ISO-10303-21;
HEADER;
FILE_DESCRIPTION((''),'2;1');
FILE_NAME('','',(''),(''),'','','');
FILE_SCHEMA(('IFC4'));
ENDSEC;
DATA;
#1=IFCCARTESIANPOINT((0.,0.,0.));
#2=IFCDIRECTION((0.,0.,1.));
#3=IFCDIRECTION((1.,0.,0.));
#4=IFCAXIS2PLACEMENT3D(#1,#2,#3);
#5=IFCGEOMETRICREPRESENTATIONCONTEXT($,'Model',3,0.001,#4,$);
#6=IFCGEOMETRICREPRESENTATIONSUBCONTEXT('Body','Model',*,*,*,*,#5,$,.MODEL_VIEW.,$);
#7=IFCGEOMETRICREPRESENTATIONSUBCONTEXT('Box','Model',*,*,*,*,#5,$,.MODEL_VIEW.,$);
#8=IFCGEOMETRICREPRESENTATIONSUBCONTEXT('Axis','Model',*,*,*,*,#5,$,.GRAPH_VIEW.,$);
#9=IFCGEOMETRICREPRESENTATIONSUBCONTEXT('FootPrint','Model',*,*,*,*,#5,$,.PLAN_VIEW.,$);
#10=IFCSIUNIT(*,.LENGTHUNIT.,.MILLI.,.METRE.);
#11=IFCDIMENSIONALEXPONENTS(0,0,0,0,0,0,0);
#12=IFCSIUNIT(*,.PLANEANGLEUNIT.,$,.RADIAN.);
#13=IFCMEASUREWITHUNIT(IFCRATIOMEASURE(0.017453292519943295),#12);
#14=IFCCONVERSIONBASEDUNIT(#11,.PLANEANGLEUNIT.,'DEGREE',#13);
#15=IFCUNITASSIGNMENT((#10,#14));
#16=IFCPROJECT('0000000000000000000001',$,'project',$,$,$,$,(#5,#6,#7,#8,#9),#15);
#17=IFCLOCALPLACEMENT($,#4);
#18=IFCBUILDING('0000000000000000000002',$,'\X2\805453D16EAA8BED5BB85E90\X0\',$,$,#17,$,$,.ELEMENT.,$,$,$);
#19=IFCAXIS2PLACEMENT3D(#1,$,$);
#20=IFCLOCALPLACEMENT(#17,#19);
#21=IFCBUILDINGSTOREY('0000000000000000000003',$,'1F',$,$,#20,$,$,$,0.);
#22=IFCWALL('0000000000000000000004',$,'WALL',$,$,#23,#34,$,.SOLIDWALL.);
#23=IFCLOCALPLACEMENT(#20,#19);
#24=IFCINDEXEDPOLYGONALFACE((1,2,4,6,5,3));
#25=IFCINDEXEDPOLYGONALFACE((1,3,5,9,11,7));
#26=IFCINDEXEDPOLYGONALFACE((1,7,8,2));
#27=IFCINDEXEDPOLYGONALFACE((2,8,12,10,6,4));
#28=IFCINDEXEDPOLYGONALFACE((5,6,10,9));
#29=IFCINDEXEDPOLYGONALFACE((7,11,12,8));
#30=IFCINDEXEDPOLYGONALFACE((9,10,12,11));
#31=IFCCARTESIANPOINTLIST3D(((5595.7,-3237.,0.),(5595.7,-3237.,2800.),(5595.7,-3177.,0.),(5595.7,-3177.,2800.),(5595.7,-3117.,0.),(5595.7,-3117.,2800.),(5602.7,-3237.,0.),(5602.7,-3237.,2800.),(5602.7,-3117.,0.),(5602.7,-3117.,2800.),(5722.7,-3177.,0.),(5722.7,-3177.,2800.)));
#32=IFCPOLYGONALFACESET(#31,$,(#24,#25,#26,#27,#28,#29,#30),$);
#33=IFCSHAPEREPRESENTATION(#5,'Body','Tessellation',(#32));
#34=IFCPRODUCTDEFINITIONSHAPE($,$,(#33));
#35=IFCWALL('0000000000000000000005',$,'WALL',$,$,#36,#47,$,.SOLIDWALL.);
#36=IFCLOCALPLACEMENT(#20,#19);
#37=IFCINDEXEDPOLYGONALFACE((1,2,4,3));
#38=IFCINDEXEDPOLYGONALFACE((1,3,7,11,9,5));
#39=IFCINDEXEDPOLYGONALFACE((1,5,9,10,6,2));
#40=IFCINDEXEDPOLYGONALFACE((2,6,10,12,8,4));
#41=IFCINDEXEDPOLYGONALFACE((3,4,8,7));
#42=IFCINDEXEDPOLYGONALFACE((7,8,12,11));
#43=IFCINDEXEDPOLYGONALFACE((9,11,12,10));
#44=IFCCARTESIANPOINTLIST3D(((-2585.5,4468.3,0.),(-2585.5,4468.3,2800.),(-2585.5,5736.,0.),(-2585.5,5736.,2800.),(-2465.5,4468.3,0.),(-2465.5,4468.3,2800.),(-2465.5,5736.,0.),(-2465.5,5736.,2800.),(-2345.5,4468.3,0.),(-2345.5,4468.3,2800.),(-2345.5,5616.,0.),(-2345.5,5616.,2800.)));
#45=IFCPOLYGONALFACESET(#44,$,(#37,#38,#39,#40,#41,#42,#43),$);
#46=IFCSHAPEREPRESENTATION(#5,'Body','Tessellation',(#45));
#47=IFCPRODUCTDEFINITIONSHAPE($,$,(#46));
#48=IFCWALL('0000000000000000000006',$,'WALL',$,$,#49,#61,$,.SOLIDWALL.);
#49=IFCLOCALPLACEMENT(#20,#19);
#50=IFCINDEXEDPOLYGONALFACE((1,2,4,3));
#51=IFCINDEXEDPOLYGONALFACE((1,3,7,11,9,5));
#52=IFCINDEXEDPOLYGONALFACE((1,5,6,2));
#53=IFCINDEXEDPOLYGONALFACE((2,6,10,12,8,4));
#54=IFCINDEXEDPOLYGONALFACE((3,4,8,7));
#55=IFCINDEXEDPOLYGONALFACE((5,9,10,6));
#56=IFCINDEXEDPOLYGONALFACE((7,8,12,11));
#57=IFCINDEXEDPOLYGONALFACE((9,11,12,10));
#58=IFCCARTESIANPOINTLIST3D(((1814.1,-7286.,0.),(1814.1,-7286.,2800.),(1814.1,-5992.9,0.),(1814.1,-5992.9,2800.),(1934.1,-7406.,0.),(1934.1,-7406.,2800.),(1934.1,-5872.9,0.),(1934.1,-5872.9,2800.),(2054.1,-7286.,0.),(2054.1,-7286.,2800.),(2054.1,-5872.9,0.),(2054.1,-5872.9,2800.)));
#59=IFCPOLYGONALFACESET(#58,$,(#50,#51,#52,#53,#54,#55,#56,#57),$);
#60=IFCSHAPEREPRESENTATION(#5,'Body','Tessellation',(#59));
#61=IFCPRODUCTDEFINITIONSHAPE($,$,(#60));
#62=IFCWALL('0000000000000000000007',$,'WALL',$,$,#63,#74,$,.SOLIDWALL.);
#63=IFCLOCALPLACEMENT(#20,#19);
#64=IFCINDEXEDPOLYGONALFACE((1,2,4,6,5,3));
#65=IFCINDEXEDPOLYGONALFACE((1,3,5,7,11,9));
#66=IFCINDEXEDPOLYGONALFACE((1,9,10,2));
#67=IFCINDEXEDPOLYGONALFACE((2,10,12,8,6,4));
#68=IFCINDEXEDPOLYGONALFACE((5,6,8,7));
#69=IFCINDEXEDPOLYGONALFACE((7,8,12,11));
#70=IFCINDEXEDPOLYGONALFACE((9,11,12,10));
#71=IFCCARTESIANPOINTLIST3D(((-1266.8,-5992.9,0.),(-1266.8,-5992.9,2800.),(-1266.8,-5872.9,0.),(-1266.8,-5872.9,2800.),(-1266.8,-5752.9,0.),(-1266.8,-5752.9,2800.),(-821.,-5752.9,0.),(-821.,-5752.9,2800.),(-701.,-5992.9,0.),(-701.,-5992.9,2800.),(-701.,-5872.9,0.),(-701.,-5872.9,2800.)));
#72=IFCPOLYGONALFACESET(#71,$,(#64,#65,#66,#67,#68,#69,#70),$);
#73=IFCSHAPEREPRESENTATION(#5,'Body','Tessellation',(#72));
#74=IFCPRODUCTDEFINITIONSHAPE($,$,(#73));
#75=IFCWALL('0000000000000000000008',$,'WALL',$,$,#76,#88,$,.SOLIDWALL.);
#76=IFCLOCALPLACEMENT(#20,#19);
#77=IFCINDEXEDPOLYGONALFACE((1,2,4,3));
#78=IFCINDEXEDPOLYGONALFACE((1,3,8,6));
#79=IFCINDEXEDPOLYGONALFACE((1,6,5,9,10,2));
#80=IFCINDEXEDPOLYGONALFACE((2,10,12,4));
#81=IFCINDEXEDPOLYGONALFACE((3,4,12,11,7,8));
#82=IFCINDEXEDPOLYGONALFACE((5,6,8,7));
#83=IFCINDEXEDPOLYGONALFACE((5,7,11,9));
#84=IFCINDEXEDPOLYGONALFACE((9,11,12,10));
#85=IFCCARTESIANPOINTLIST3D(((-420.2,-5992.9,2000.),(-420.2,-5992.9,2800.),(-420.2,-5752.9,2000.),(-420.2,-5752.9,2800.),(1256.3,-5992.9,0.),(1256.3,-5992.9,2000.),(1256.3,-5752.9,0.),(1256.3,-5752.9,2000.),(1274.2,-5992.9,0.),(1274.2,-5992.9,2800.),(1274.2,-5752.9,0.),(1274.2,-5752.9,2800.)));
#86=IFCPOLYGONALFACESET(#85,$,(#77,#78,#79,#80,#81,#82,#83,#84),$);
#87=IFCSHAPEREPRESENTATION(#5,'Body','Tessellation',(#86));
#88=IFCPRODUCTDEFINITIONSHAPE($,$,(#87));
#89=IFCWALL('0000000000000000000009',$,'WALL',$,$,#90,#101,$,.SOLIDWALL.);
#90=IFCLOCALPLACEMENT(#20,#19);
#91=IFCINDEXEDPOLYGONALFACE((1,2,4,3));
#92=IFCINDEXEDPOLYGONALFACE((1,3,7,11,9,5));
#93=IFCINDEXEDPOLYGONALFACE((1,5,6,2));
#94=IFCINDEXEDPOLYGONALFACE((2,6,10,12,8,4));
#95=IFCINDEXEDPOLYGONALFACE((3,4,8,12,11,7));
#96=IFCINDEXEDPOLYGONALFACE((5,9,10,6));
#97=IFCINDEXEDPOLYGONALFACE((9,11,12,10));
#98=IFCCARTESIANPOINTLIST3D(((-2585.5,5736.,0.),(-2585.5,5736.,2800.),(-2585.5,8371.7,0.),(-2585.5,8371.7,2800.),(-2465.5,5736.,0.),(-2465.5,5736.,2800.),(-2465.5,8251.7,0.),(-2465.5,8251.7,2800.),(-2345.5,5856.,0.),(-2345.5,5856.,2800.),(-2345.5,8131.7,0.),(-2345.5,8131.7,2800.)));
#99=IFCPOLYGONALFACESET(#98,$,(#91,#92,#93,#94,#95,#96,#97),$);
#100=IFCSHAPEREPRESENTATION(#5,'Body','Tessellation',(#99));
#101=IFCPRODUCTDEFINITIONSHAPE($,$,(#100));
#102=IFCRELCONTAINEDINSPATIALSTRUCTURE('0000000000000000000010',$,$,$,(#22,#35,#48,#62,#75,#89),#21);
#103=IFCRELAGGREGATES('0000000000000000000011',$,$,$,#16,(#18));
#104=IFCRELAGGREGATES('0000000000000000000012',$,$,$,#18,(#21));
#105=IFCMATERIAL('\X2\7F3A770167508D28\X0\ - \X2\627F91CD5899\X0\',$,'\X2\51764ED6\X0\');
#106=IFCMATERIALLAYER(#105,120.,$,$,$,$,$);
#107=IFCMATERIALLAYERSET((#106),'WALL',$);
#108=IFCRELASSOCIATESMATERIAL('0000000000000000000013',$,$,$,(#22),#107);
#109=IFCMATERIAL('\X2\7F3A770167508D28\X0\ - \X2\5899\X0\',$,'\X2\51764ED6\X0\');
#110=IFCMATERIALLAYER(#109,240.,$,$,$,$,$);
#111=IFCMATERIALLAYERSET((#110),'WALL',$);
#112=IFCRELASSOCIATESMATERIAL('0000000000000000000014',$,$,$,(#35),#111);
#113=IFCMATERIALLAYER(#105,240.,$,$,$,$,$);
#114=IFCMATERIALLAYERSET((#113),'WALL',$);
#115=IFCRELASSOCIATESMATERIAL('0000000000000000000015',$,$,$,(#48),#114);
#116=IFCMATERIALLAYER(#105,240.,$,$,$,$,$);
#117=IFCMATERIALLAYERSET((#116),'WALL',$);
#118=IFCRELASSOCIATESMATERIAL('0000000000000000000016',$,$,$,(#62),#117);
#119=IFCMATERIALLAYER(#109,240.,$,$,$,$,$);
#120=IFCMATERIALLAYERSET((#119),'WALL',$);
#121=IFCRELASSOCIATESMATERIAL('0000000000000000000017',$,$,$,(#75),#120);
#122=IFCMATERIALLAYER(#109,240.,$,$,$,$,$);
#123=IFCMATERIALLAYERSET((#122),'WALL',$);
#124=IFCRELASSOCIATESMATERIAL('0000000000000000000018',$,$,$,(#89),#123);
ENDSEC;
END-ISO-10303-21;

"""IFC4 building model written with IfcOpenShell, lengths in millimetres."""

from ifc_helpers import new_model, entity, si_unit, converted_unit, origin, origin_with_axes, place, context, subcontext, project, spatial, polyline, segment, composite_curve, outline, extrude, material, layer, layer_set, layer_usage, element, save


model = new_model("IFC4")

# Units and contexts
model_context = context("Model", 3, precision=0.001, world=origin_with_axes())
body_context = subcontext(model_context, "Body", "Model", "MODEL_VIEW")
box_context = subcontext(model_context, "Box", "Model", "MODEL_VIEW")
axis_context = subcontext(model_context, "Axis", "Model", "GRAPH_VIEW")
footprint_context = subcontext(model_context, "FootPrint", "Model", "PLAN_VIEW")
ifc_project = project(units=[si_unit("LENGTHUNIT", "METRE", prefix="MILLI"), converted_unit("PLANEANGLEUNIT", "DEGREE", entity("IfcRatioMeasure", 0.017453292519943295), si_unit("PLANEANGLEUNIT", "RADIAN"), dimensions=[0, 0, 0, 0, 0, 0, 0])], contexts=[model_context, body_context, box_context, axis_context, footprint_context])

# Building, storey
building_placement = place(None, origin_with_axes())
building = spatial("IfcBuilding", under=ifc_project, at=building_placement, Name="联发溪语宸庐", CompositionType="ELEMENT")
storey_placement = place(building_placement, origin())
storey = spatial("IfcBuildingStorey", under=building, at=storey_placement, Name="1F", Elevation=0.0)

# Shared definitions
ifc_material_1 = material(Name="缺省材质 - 墙", Category="其他")

# Shared definitions
ifc_material_2 = material(Name="缺省材质 - 承重墙", Category="其他")

# Walls
ifc_layer_1 = layer(ifc_material_2, 120.0)
ifc_layer_set_1 = layer_set([ifc_layer_1], Name="WALL")
ifc_layer_usage_1 = layer_usage(ifc_layer_set_1, "AXIS2", "NEGATIVE", 60.0)
wall_1_placement = place(None, origin_with_axes())
element("IfcWall", 1, at=wall_1_placement, inside=storey, material=ifc_layer_usage_1, Name="WALL", PredefinedType="SOLIDWALL", context=model_context, shape_type="SweptSolid", body=[
    extrude(outline(composite_curve([segment(polyline([(5595.7, -3177.0), (5595.7, -3237.0)]), True, "CONTINUOUS"), segment(polyline([(5595.7, -3237.0), (5602.7, -3237.0)]), True, "CONTINUOUS"), segment(polyline([(5602.7, -3237.0), (5722.7, -3177.0)]), True, "CONTINUOUS"), segment(polyline([(5722.7, -3177.0), (5602.7, -3117.0)]), True, "CONTINUOUS"), segment(polyline([(5602.7, -3117.0), (5595.7, -3117.0)]), True, "CONTINUOUS"), segment(polyline([(5595.7, -3117.0), (5595.7, -3177.0)]), True, "CONTINUOUS")], self_intersect=False)), origin(), (0.0, 0.0, 1.0), 2800.0),
])
ifc_layer_2 = layer(ifc_material_1, 240.0)
ifc_layer_set_2 = layer_set([ifc_layer_2], Name="WALL")
ifc_layer_usage_2 = layer_usage(ifc_layer_set_2, "AXIS2", "NEGATIVE", 120.0)
wall_2_placement = place(None, origin_with_axes())
element("IfcWall", 2, at=wall_2_placement, inside=storey, material=ifc_layer_usage_2, Name="WALL", PredefinedType="SOLIDWALL", context=model_context, shape_type="SweptSolid", body=[
    extrude(outline(composite_curve([segment(polyline([(-2465.5, 4468.3), (-2345.5, 4468.3)]), True, "CONTINUOUS"), segment(polyline([(-2345.5, 4468.3), (-2345.5, 5616.0)]), True, "CONTINUOUS"), segment(polyline([(-2345.5, 5616.0), (-2465.5, 5736.0)]), True, "CONTINUOUS"), segment(polyline([(-2465.5, 5736.0), (-2585.5, 5736.0)]), True, "CONTINUOUS"), segment(polyline([(-2585.5, 5736.0), (-2585.5, 4468.3)]), True, "CONTINUOUS"), segment(polyline([(-2585.5, 4468.3), (-2465.5, 4468.3)]), True, "CONTINUOUS")], self_intersect=False)), origin(), (0.0, 0.0, 1.0), 2800.0),
])
ifc_layer_3 = layer(ifc_material_2, 240.0)
ifc_layer_set_3 = layer_set([ifc_layer_3], Name="WALL")
ifc_layer_usage_3 = layer_usage(ifc_layer_set_3, "AXIS2", "NEGATIVE", 120.0)
wall_3_placement = place(None, origin_with_axes())
element("IfcWall", 3, at=wall_3_placement, inside=storey, material=ifc_layer_usage_3, Name="WALL", PredefinedType="SOLIDWALL", context=model_context, shape_type="SweptSolid", body=[
    extrude(outline(composite_curve([segment(polyline([(1934.1, -7406.0), (2054.1, -7286.0)]), True, "CONTINUOUS"), segment(polyline([(2054.1, -7286.0), (2054.1, -5872.9)]), True, "CONTINUOUS"), segment(polyline([(2054.1, -5872.9), (1934.1, -5872.9)]), True, "CONTINUOUS"), segment(polyline([(1934.1, -5872.9), (1814.1, -5992.9)]), True, "CONTINUOUS"), segment(polyline([(1814.1, -5992.9), (1814.1, -7286.0)]), True, "CONTINUOUS"), segment(polyline([(1814.1, -7286.0), (1934.1, -7406.0)]), True, "CONTINUOUS")], self_intersect=False)), origin(), (0.0, 0.0, 1.0), 2800.0),
])
ifc_layer_4 = layer(ifc_material_2, 240.0)
ifc_layer_set_4 = layer_set([ifc_layer_4], Name="WALL")
ifc_layer_usage_4 = layer_usage(ifc_layer_set_4, "AXIS2", "NEGATIVE", 120.0)
wall_4_placement = place(None, origin_with_axes())
element("IfcWall", 4, at=wall_4_placement, inside=storey, material=ifc_layer_usage_4, Name="WALL", PredefinedType="SOLIDWALL", context=model_context, shape_type="SweptSolid", body=[
    extrude(outline(composite_curve([segment(polyline([(-1266.8, -5872.9), (-1266.8, -5992.9)]), True, "CONTINUOUS"), segment(polyline([(-1266.8, -5992.9), (-701.0, -5992.9)]), True, "CONTINUOUS"), segment(polyline([(-701.0, -5992.9), (-701.0, -5872.9)]), True, "CONTINUOUS"), segment(polyline([(-701.0, -5872.9), (-821.0, -5752.9)]), True, "CONTINUOUS"), segment(polyline([(-821.0, -5752.9), (-1266.8, -5752.9)]), True, "CONTINUOUS"), segment(polyline([(-1266.8, -5752.9), (-1266.8, -5872.9)]), True, "CONTINUOUS")], self_intersect=False)), origin(), (0.0, 0.0, 1.0), 2800.0),
])

# Wall, opening
ifc_layer_5 = layer(ifc_material_1, 240.0)
ifc_layer_set_5 = layer_set([ifc_layer_5], Name="WALL")
ifc_layer_usage_5 = layer_usage(ifc_layer_set_5, "AXIS2", "NEGATIVE", 120.0)
wall_5_placement = place(None, origin_with_axes())
wall_5 = element("IfcWall", 5, at=wall_5_placement, inside=storey, material=ifc_layer_usage_5, Name="WALL", PredefinedType="SOLIDWALL", context=model_context, shape_type="SweptSolid", body=[
    extrude(outline(composite_curve([segment(polyline([(-420.2, -5872.9), (-420.2, -5992.9)]), True, "CONTINUOUS"), segment(polyline([(-420.2, -5992.9), (1274.2, -5992.9)]), True, "CONTINUOUS"), segment(polyline([(1274.2, -5992.9), (1274.2, -5872.9)]), True, "CONTINUOUS"), segment(polyline([(1274.2, -5872.9), (1274.2, -5752.9)]), True, "CONTINUOUS"), segment(polyline([(1274.2, -5752.9), (-420.2, -5752.9)]), True, "CONTINUOUS"), segment(polyline([(-420.2, -5752.9), (-420.2, -5872.9)]), True, "CONTINUOUS")], self_intersect=False)), origin(), (0.0, 0.0, 1.0), 2800.0),
])
opening_1_placement = place(None, origin_with_axes())
element("IfcOpeningElement", 6, at=opening_1_placement, cuts=wall_5, ObjectType="OPENING", PredefinedType="OPENING", context=model_context, shape_type="SweptSolid", body=[
    extrude(outline(composite_curve([segment(polyline([(1256.3, -5752.9), (-420.2, -5752.9)]), True, "CONTINUOUS"), segment(polyline([(-420.2, -5752.9), (-420.2, -5992.9)]), True, "CONTINUOUS"), segment(polyline([(-420.2, -5992.9), (1256.3, -5992.9)]), True, "CONTINUOUS"), segment(polyline([(1256.3, -5992.9), (1256.3, -5752.9)]), True, "CONTINUOUS")], self_intersect=False)), origin_with_axes(), (0.0, 0.0, 1.0), 2000.0),
])

# Wall
ifc_layer_6 = layer(ifc_material_1, 240.0)
ifc_layer_set_6 = layer_set([ifc_layer_6], Name="WALL")
ifc_layer_usage_6 = layer_usage(ifc_layer_set_6, "AXIS2", "NEGATIVE", 120.0)
wall_6_placement = place(None, origin_with_axes())
element("IfcWall", 7, at=wall_6_placement, inside=storey, material=ifc_layer_usage_6, Name="WALL", PredefinedType="SOLIDWALL", context=model_context, shape_type="SweptSolid", body=[
    extrude(outline(composite_curve([segment(polyline([(-2465.5, 5736.0), (-2345.5, 5856.0)]), True, "CONTINUOUS"), segment(polyline([(-2345.5, 5856.0), (-2345.5, 8131.7)]), True, "CONTINUOUS"), segment(polyline([(-2345.5, 8131.7), (-2465.5, 8251.7)]), True, "CONTINUOUS"), segment(polyline([(-2465.5, 8251.7), (-2585.5, 8371.7)]), True, "CONTINUOUS"), segment(polyline([(-2585.5, 8371.7), (-2585.5, 5736.0)]), True, "CONTINUOUS"), segment(polyline([(-2585.5, 5736.0), (-2465.5, 5736.0)]), True, "CONTINUOUS")], self_intersect=False)), origin(), (0.0, 0.0, 1.0), 2800.0),
])

save(model, "model.ifc")
